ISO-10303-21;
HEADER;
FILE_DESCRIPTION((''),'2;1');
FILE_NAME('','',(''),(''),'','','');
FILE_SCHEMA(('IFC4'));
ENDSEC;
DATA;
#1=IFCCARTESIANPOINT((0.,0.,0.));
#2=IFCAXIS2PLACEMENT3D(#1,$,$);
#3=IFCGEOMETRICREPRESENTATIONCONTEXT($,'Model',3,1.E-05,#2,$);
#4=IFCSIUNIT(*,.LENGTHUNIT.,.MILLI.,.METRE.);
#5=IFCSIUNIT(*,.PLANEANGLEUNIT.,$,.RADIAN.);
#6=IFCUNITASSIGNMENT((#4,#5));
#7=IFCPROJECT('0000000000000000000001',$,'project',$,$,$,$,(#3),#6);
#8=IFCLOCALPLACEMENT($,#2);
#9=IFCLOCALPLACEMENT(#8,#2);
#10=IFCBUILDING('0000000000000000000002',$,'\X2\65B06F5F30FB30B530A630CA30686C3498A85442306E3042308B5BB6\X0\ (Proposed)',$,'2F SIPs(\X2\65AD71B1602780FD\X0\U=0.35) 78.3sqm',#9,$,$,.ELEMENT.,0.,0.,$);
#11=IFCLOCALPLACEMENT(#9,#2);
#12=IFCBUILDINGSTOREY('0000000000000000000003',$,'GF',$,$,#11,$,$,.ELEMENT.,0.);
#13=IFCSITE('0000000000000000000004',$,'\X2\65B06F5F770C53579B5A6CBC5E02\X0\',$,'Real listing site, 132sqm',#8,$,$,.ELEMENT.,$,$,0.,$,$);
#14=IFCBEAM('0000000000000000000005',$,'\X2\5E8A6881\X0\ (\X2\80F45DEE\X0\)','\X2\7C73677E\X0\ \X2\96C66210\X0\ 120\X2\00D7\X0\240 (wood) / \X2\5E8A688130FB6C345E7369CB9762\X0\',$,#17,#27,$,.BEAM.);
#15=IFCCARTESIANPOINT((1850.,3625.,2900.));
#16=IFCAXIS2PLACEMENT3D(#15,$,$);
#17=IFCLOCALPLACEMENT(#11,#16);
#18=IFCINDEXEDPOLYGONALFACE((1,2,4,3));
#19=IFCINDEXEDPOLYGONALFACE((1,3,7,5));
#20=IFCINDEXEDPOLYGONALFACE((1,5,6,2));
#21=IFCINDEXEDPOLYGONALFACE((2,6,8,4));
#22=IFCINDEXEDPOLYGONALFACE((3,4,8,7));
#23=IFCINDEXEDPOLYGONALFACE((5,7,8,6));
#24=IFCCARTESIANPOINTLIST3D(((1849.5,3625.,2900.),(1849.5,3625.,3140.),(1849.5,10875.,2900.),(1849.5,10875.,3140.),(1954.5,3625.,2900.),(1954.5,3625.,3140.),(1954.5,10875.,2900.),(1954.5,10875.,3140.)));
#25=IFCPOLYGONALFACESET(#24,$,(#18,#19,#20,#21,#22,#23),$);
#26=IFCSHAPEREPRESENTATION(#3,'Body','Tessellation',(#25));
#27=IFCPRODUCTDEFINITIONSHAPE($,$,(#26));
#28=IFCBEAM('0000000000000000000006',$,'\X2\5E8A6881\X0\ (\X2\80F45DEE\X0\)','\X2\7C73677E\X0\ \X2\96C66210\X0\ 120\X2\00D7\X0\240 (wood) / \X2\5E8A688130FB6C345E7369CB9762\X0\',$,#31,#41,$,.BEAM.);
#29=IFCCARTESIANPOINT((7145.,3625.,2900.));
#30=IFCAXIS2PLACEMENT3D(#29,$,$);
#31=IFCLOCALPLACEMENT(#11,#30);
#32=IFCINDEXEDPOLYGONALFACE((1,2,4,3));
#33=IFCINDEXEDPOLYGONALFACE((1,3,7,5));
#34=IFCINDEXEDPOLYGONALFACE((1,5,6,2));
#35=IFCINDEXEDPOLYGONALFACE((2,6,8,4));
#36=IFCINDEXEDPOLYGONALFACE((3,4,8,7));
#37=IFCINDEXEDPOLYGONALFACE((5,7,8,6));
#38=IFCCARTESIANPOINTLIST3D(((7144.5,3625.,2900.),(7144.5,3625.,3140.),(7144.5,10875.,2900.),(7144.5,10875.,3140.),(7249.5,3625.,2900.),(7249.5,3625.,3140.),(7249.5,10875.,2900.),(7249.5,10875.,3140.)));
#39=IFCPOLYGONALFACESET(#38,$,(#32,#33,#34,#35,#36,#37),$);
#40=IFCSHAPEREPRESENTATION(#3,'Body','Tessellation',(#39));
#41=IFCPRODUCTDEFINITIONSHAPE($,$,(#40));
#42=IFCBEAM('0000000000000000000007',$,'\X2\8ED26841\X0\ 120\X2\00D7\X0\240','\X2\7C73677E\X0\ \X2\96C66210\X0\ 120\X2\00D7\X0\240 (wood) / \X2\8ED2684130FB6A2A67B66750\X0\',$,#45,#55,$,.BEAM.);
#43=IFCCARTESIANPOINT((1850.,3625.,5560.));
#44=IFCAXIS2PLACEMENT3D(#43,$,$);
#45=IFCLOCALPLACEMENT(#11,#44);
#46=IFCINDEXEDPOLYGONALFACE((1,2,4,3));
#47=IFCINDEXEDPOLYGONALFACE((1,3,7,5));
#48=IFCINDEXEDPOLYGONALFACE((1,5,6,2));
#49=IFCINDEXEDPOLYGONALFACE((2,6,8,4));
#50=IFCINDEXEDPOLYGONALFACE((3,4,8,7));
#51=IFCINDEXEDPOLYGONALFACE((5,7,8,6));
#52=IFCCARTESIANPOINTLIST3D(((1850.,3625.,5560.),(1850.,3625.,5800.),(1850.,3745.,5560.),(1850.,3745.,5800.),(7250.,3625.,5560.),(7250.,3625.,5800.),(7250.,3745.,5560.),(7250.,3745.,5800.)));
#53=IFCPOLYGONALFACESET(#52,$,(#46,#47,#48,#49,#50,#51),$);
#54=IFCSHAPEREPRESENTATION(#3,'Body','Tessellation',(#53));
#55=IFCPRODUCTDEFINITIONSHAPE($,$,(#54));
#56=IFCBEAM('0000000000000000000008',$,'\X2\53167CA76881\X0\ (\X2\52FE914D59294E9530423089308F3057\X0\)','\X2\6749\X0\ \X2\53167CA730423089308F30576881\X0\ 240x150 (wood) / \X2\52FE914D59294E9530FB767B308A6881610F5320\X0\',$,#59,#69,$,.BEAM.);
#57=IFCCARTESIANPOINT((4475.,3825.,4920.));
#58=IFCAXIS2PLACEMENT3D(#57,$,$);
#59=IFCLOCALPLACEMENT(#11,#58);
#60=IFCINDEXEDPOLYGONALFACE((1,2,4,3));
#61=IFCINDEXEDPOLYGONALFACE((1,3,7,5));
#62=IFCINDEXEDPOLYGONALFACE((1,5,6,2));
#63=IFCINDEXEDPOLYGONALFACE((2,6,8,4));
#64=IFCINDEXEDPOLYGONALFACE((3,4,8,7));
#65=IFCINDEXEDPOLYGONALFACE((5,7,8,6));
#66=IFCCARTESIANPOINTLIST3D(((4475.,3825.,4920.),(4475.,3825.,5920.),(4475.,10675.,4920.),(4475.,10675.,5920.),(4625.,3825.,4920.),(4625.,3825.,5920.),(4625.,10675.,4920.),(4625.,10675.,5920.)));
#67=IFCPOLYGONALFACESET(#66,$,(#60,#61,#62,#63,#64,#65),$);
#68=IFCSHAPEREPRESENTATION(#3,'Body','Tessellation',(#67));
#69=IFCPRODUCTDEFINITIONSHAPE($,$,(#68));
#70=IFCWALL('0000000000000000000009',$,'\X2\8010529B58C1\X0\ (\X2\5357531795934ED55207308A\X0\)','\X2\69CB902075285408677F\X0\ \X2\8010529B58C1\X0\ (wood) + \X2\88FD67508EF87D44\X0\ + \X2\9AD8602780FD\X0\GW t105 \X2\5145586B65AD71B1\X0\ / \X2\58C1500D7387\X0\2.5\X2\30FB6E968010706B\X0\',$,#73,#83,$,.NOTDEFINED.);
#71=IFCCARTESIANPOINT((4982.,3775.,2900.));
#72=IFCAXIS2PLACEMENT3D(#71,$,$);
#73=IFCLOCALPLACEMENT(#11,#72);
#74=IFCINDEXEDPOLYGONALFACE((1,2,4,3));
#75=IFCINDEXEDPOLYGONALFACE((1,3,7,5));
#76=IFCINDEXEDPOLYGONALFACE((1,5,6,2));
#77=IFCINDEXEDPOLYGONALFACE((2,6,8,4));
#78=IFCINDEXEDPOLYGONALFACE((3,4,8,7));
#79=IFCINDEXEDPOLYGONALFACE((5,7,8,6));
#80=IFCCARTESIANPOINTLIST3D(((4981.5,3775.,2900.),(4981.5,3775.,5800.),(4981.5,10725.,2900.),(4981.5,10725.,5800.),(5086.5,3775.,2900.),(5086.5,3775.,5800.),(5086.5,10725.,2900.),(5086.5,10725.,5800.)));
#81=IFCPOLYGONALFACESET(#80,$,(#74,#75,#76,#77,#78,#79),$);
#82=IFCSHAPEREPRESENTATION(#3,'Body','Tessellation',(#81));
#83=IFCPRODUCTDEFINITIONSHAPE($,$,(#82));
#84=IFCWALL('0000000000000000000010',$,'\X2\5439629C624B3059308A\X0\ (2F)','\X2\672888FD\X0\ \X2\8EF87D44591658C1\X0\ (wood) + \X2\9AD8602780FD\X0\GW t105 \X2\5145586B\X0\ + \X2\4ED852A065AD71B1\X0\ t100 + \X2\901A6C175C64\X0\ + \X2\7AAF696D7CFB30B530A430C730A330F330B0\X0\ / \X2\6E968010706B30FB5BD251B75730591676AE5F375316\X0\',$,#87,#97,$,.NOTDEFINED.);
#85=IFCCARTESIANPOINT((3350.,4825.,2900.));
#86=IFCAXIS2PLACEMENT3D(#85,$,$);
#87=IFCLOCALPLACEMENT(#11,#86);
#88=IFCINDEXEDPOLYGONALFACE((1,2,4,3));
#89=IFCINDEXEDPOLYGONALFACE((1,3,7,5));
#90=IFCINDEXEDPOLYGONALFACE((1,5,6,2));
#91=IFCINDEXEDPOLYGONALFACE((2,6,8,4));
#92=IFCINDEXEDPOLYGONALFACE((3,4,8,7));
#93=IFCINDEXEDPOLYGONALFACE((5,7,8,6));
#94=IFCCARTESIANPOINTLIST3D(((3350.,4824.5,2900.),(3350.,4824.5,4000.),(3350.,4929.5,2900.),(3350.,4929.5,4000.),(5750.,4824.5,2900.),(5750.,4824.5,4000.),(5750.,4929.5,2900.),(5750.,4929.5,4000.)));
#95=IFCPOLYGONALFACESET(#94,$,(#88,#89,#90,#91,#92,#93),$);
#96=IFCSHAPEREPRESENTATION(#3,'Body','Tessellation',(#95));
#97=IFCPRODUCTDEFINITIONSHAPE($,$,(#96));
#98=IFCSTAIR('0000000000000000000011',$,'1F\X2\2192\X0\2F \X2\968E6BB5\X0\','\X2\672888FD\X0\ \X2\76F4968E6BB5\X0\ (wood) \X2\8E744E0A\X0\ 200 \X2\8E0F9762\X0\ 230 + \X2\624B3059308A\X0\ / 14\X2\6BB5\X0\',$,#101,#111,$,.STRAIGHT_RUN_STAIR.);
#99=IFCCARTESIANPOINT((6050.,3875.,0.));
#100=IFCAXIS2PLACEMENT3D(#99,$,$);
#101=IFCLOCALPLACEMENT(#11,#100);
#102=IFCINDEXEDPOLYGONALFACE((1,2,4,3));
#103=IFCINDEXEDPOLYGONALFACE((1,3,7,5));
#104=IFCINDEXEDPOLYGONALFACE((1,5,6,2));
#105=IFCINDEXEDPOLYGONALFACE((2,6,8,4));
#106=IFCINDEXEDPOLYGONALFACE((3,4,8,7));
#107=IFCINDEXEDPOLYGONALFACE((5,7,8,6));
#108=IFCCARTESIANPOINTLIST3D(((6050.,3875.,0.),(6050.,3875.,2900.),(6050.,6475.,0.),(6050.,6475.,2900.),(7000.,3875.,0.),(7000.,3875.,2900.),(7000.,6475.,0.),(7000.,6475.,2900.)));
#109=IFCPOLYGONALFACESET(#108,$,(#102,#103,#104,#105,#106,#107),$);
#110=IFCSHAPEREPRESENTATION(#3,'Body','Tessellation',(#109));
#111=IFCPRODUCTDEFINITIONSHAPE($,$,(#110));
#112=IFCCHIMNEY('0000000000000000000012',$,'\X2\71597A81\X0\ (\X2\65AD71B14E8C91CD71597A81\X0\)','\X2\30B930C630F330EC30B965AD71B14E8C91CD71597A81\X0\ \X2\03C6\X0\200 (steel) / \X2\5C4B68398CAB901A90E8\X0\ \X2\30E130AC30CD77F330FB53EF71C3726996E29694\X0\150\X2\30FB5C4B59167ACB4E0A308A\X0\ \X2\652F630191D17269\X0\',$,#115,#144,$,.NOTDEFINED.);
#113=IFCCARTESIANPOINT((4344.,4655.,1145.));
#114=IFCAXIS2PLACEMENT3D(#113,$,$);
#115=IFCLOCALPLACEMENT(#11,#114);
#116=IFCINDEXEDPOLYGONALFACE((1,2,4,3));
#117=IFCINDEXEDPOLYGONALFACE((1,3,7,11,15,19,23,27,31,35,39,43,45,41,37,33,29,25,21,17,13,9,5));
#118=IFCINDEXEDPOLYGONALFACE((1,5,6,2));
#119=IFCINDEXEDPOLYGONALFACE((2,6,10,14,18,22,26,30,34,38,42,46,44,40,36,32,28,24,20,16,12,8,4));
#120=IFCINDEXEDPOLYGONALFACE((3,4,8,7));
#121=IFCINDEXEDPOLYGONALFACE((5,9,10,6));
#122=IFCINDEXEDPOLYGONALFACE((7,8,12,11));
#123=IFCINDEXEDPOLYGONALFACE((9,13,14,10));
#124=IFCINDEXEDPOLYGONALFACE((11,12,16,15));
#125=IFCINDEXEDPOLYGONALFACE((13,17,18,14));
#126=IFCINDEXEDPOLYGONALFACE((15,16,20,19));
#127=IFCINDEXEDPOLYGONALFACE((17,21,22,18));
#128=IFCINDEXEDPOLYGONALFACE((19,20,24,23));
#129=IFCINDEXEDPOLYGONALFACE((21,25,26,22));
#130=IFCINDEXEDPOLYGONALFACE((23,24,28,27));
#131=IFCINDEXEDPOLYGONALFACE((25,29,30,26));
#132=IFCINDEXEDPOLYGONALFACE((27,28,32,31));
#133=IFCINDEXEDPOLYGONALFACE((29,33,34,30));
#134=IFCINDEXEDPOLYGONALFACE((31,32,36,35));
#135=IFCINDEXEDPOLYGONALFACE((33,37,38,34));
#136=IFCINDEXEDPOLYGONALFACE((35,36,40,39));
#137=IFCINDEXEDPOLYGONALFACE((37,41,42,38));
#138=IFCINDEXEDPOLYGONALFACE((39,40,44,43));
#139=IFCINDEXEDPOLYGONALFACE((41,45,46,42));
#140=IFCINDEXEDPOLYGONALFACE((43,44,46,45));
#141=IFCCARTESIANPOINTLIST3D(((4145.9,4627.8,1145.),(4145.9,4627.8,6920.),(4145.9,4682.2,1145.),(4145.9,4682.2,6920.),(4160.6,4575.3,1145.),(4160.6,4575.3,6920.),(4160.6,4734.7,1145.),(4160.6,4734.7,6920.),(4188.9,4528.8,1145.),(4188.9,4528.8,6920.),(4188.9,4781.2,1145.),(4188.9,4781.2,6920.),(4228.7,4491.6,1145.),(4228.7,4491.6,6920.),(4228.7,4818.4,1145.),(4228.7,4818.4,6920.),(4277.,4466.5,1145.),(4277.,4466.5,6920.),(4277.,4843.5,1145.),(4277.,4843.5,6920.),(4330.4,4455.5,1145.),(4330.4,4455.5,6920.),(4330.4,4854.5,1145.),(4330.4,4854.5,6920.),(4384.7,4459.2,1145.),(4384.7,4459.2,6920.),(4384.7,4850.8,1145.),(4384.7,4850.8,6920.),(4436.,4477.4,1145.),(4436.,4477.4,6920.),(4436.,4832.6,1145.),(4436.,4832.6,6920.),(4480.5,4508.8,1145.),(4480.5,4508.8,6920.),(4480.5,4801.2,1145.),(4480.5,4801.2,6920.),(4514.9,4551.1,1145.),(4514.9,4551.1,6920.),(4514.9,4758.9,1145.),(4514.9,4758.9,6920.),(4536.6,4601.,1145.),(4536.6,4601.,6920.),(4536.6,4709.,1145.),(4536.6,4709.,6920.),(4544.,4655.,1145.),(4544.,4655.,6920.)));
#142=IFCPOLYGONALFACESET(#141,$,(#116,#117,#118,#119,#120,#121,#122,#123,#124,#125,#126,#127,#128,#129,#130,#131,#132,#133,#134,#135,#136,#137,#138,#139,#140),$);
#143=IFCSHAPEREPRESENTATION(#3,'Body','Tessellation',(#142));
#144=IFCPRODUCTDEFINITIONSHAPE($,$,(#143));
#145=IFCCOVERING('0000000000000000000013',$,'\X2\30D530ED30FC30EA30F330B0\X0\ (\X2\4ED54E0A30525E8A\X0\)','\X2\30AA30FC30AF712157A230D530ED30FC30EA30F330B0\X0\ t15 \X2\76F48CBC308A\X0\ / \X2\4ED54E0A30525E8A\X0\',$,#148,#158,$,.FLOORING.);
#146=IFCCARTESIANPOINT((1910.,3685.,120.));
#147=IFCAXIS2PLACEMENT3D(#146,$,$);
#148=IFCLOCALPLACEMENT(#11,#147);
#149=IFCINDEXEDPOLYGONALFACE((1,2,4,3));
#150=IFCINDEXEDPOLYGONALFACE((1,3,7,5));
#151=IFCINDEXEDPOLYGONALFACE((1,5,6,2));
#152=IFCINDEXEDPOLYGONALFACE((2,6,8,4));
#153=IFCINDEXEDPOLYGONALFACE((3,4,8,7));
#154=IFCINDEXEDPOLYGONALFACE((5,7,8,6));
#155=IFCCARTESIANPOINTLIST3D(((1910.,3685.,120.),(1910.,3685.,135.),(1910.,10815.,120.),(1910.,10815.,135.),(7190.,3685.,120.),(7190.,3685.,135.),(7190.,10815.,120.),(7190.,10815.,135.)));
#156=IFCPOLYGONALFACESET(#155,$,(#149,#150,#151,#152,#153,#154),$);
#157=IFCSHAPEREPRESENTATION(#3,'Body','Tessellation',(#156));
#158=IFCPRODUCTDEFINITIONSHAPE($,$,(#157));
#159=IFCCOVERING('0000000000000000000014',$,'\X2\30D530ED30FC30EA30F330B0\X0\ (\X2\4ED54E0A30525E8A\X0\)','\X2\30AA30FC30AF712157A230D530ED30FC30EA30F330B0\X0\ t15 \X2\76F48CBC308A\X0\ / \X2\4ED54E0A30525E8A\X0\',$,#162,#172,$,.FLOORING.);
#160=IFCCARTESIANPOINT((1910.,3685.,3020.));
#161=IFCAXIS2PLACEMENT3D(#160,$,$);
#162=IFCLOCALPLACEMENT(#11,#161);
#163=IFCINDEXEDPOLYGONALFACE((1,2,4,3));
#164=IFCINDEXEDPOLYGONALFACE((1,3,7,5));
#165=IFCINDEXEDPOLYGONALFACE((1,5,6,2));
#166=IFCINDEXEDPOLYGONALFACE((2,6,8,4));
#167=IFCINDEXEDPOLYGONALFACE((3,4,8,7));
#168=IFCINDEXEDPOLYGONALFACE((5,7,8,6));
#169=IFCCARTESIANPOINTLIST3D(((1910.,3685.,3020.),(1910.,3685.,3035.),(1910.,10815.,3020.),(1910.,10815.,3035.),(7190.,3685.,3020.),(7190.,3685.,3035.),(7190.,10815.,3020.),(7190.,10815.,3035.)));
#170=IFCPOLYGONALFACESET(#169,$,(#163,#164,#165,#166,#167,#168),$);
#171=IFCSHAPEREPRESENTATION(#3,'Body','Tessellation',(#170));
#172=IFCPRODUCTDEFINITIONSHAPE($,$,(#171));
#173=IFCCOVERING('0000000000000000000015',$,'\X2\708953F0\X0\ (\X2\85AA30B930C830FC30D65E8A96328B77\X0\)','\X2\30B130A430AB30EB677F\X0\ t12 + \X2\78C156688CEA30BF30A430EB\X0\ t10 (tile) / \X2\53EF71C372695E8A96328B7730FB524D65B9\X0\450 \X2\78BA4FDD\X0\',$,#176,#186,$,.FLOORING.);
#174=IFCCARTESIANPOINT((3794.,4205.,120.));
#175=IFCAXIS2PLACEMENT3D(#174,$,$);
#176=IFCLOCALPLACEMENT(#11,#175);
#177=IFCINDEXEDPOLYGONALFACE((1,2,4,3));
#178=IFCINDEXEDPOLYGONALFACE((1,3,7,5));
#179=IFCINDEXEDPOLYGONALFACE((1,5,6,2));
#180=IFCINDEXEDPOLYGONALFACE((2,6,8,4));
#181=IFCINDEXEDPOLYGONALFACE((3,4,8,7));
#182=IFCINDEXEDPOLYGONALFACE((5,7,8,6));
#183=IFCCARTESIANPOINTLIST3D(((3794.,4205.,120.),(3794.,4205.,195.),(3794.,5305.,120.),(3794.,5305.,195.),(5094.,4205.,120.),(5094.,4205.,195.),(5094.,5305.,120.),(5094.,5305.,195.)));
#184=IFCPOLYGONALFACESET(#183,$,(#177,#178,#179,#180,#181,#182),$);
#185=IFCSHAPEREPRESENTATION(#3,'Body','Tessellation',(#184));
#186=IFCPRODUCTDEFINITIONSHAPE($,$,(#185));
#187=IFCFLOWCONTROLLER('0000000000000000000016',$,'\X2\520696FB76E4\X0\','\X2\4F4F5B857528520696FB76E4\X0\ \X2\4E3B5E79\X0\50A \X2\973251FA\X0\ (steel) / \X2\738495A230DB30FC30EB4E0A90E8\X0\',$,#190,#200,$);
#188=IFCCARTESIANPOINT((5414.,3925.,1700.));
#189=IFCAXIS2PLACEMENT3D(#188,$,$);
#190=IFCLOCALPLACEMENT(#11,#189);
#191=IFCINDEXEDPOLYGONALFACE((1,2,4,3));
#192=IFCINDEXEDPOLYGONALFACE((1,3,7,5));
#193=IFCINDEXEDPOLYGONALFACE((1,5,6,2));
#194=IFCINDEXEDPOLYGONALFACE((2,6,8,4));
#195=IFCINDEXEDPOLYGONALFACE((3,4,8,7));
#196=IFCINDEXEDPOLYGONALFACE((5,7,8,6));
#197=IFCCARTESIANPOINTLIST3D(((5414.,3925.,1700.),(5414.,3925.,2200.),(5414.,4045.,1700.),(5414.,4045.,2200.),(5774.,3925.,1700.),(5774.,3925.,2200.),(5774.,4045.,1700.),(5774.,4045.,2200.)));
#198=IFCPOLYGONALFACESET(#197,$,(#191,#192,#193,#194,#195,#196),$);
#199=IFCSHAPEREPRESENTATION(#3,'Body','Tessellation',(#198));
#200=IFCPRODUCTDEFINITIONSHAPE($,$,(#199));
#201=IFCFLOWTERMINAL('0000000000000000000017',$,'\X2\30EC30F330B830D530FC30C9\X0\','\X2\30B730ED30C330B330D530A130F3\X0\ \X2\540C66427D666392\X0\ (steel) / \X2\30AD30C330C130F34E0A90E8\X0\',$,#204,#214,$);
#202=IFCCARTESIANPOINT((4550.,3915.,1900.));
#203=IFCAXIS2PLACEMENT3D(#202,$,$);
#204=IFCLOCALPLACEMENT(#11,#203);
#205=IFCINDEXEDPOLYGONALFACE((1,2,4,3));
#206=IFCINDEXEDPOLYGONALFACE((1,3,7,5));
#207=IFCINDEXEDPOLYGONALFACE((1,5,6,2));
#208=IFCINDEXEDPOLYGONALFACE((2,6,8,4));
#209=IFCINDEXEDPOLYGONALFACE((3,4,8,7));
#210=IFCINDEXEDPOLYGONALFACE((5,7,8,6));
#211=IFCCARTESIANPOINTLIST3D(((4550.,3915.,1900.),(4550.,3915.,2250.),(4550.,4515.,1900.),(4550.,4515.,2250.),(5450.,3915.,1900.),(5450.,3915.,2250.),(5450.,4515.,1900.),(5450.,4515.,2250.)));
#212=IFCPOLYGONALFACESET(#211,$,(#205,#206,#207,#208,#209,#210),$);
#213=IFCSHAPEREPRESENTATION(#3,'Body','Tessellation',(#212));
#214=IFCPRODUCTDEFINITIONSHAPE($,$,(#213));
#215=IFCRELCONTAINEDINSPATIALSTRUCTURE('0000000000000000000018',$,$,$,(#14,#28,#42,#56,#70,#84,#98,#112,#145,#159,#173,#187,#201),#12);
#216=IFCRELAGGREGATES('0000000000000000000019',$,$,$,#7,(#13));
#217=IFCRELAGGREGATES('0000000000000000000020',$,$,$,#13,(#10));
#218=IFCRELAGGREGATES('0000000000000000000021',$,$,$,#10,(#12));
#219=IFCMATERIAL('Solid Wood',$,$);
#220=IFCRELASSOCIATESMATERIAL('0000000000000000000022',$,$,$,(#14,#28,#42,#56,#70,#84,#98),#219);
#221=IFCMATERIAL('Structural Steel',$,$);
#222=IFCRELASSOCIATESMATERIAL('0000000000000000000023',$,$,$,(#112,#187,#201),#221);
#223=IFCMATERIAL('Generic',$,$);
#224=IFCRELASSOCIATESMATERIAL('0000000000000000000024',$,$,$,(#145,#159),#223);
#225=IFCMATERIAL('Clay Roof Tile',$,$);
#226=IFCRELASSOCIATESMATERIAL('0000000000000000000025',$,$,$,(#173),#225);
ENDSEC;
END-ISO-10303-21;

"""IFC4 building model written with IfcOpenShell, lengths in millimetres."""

from ifc_helpers import new_model, si_unit, frame, frame_2d, origin, origin_2d, place, context, project, spatial, rectangle, circle, extrude, material, element, save


model = new_model("IFC4")

# Units and contexts
model_context = context("Model", 3, precision=1e-05, world=origin())
ifc_project = project(units=[si_unit("LENGTHUNIT", "METRE", prefix="MILLI"), si_unit("PLANEANGLEUNIT", "RADIAN")], contexts=[model_context])

# Site, building, storey
site_placement = place(None, origin())
site = spatial("IfcSite", under=ifc_project, at=site_placement, Name="新潟県南魚沼市", ObjectType="Real listing site, 132sqm", CompositionType="ELEMENT", RefElevation=0.0)
building_placement = place(site_placement, origin())
building = spatial("IfcBuilding", under=site, at=building_placement, Name="新潟・サウナと水風呂のある家 (Proposed)", ObjectType="2F SIPs(断熱性能U=0.35) 78.3sqm", CompositionType="ELEMENT", ElevationOfRefHeight=0.0, ElevationOfTerrain=0.0)
storey_placement = place(building_placement, origin())
storey = spatial("IfcBuildingStorey", under=building, at=storey_placement, Name="GF", CompositionType="ELEMENT", Elevation=0.0)

# Beams
ifc_material_1 = material(Name="Solid Wood")
beam_1_placement = place(storey_placement, frame((1850.0, 3625.0, 2900.0)))
element("IfcBeam", 1, at=beam_1_placement, inside=storey, material=ifc_material_1, Name="床梁 (胴差)", Description="米松 集成 120×240 (wood) / 床梁・水平構面", PredefinedType="BEAM", context=model_context, shape_type="SweptSolid", body=[
    extrude(rectangle(XDim=105.0, YDim=7250.0, at=frame_2d((52.0, 3625.0))), frame((1850.0, 3625.0, 2900.0)), (0.0, 0.0, 1.0), 240.0),
])
beam_2_placement = place(storey_placement, frame((7145.0, 3625.0, 2900.0)))
element("IfcBeam", 2, at=beam_2_placement, inside=storey, material=ifc_material_1, Name="床梁 (胴差)", Description="米松 集成 120×240 (wood) / 床梁・水平構面", PredefinedType="BEAM", context=model_context, shape_type="SweptSolid", body=[
    extrude(rectangle(XDim=105.0, YDim=7250.0, at=frame_2d((52.0, 3625.0))), frame((7145.0, 3625.0, 2900.0)), (0.0, 0.0, 1.0), 240.0),
])
beam_3_placement = place(storey_placement, frame((1850.0, 3625.0, 5560.0)))
element("IfcBeam", 3, at=beam_3_placement, inside=storey, material=ifc_material_1, Name="軒桁 120×240", Description="米松 集成 120×240 (wood) / 軒桁・横架材", PredefinedType="BEAM", context=model_context, shape_type="SweptSolid", body=[
    extrude(rectangle(XDim=5400.0, YDim=120.0, at=frame_2d((2700.0, 60.0))), frame((1850.0, 3625.0, 5560.0)), (0.0, 0.0, 1.0), 240.0),
])
beam_4_placement = place(storey_placement, frame((4475.0, 3825.0, 4920.0)))
element("IfcBeam", 4, at=beam_4_placement, inside=storey, material=ifc_material_1, Name="化粧梁 (勾配天井あらわし)", Description="杉 化粧あらわし梁 240x150 (wood) / 勾配天井・登り梁意匠", PredefinedType="BEAM", context=model_context, shape_type="SweptSolid", body=[
    extrude(rectangle(XDim=150.0, YDim=6850.0, at=frame_2d((75.0, 3425.0))), frame((4475.0, 3825.0, 4920.0)), (0.0, 0.0, 1.0), 1000.0),
])

# Walls
wall_1_placement = place(storey_placement, frame((4982.0, 3775.0, 2900.0)))
element("IfcWall", 5, at=wall_1_placement, inside=storey, material=ifc_material_1, Name="耐力壁 (南北間仕切り)", Description="構造用合板 耐力壁 (wood) + 製材軸組 + 高性能GW t105 充填断熱 / 壁倍率2.5・準耐火", PredefinedType="NOTDEFINED", context=model_context, shape_type="SweptSolid", body=[
    extrude(rectangle(XDim=105.0, YDim=6950.0, at=frame_2d((52.0, 3475.0))), frame((4982.0, 3775.0, 2900.0)), (0.0, 0.0, 1.0), 2900.0),
])
wall_2_placement = place(storey_placement, frame((3350.0, 4825.0, 2900.0)))
element("IfcWall", 6, at=wall_2_placement, inside=storey, material=ifc_material_1, Name="吹抜手すり (2F)", Description="木製 軸組外壁 (wood) + 高性能GW t105 充填 + 付加断熱 t100 + 通気層 + 窯業系サイディング / 準耐火・寒冷地外皮強化", PredefinedType="NOTDEFINED", context=model_context, shape_type="SweptSolid", body=[
    extrude(rectangle(XDim=2400.0, YDim=105.0, at=frame_2d((1200.0, 52.0))), frame((3350.0, 4825.0, 2900.0)), (0.0, 0.0, 1.0), 1100.0),
])

# Stair
stair_placement = place(storey_placement, frame((6050.0, 3875.0, 0.0)))
element("IfcStair", 7, at=stair_placement, inside=storey, material=ifc_material_1, Name="1F→2F 階段", Description="木製 直階段 (wood) 蹴上 200 踏面 230 + 手すり / 14段", PredefinedType="STRAIGHT_RUN_STAIR", context=model_context, shape_type="SweptSolid", body=[
    extrude(rectangle(XDim=950.0, YDim=2600.0, at=frame_2d((475.0, 1300.0))), frame((6050.0, 3875.0, 0.0)), (0.0, 0.0, 1.0), 2900.0),
])

# Chimney
ifc_material_2 = material(Name="Structural Steel")
chimney_placement = place(storey_placement, frame((4344.0, 4655.0, 1145.0)))
element("IfcChimney", 8, at=chimney_placement, inside=storey, material=ifc_material_2, Name="煙突 (断熱二重煙突)", Description="ステンレス断熱二重煙突 φ200 (steel) / 屋根貫通部 メガネ石・可燃物離隔150・屋外立上り 支持金物", PredefinedType="NOTDEFINED", context=model_context, shape_type="SweptSolid", body=[
    extrude(circle(Radius=200.0, at=origin_2d()), frame((4344.0, 4655.0, 1145.0)), (0.0, 0.0, 1.0), 5775.0),
])

# Coverings
ifc_material_3 = material(Name="Generic")
covering_1_placement = place(storey_placement, frame((1910.0, 3685.0, 120.0)))
element("IfcCovering", 9, at=covering_1_placement, inside=storey, material=ifc_material_3, Name="フローリング (仕上げ床)", Description="オーク無垢フローリング t15 直貼り / 仕上げ床", PredefinedType="FLOORING", context=model_context, shape_type="SweptSolid", body=[
    extrude(rectangle(XDim=5280.0, YDim=7130.0, at=frame_2d((2640.0, 3565.0))), frame((1910.0, 3685.0, 120.0)), (0.0, 0.0, 1.0), 15.0),
])
covering_2_placement = place(storey_placement, frame((1910.0, 3685.0, 3020.0)))
element("IfcCovering", 10, at=covering_2_placement, inside=storey, material=ifc_material_3, Name="フローリング (仕上げ床)", Description="オーク無垢フローリング t15 直貼り / 仕上げ床", PredefinedType="FLOORING", context=model_context, shape_type="SweptSolid", body=[
    extrude(rectangle(XDim=5280.0, YDim=7130.0, at=frame_2d((2640.0, 3565.0))), frame((1910.0, 3685.0, 3020.0)), (0.0, 0.0, 1.0), 15.0),
])
ifc_material_4 = material(Name="Clay Roof Tile")
covering_3_placement = place(storey_placement, frame((3794.0, 4205.0, 120.0)))
element("IfcCovering", 11, at=covering_3_placement, inside=storey, material=ifc_material_4, Name="炉台 (薪ストーブ床防護)", Description="ケイカル板 t12 + 磁器質タイル t10 (tile) / 可燃物床防護・前方450 確保", PredefinedType="FLOORING", context=model_context, shape_type="SweptSolid", body=[
    extrude(rectangle(XDim=1300.0, YDim=1100.0, at=frame_2d((650.0, 550.0))), frame((3794.0, 4205.0, 120.0)), (0.0, 0.0, 1.0), 75.0),
])

# Flow controller
flow_controller_placement = place(storey_placement, frame((5414.0, 3925.0, 1700.0)))
element("IfcFlowController", 12, at=flow_controller_placement, inside=storey, material=ifc_material_2, Name="分電盤", Description="住宅用分電盤 主幹50A 露出 (steel) / 玄関ホール上部", context=model_context, shape_type="SweptSolid", body=[
    extrude(rectangle(XDim=360.0, YDim=120.0, at=frame_2d((180.0, 60.0))), frame((5414.0, 3925.0, 1700.0)), (0.0, 0.0, 1.0), 500.0),
])

# Flow terminal
flow_terminal_1_placement = place(storey_placement, frame((4550.0, 3915.0, 1900.0)))
element("IfcFlowTerminal", 13, at=flow_terminal_1_placement, inside=storey, material=ifc_material_2, Name="レンジフード", Description="シロッコファン 同時給排 (steel) / キッチン上部", context=model_context, shape_type="SweptSolid", body=[
    extrude(rectangle(XDim=900.0, YDim=600.0, at=frame_2d((450.0, 300.0))), frame((4550.0, 3915.0, 1900.0)), (0.0, 0.0, 1.0), 350.0),
])

save(model, "model.ifc")
